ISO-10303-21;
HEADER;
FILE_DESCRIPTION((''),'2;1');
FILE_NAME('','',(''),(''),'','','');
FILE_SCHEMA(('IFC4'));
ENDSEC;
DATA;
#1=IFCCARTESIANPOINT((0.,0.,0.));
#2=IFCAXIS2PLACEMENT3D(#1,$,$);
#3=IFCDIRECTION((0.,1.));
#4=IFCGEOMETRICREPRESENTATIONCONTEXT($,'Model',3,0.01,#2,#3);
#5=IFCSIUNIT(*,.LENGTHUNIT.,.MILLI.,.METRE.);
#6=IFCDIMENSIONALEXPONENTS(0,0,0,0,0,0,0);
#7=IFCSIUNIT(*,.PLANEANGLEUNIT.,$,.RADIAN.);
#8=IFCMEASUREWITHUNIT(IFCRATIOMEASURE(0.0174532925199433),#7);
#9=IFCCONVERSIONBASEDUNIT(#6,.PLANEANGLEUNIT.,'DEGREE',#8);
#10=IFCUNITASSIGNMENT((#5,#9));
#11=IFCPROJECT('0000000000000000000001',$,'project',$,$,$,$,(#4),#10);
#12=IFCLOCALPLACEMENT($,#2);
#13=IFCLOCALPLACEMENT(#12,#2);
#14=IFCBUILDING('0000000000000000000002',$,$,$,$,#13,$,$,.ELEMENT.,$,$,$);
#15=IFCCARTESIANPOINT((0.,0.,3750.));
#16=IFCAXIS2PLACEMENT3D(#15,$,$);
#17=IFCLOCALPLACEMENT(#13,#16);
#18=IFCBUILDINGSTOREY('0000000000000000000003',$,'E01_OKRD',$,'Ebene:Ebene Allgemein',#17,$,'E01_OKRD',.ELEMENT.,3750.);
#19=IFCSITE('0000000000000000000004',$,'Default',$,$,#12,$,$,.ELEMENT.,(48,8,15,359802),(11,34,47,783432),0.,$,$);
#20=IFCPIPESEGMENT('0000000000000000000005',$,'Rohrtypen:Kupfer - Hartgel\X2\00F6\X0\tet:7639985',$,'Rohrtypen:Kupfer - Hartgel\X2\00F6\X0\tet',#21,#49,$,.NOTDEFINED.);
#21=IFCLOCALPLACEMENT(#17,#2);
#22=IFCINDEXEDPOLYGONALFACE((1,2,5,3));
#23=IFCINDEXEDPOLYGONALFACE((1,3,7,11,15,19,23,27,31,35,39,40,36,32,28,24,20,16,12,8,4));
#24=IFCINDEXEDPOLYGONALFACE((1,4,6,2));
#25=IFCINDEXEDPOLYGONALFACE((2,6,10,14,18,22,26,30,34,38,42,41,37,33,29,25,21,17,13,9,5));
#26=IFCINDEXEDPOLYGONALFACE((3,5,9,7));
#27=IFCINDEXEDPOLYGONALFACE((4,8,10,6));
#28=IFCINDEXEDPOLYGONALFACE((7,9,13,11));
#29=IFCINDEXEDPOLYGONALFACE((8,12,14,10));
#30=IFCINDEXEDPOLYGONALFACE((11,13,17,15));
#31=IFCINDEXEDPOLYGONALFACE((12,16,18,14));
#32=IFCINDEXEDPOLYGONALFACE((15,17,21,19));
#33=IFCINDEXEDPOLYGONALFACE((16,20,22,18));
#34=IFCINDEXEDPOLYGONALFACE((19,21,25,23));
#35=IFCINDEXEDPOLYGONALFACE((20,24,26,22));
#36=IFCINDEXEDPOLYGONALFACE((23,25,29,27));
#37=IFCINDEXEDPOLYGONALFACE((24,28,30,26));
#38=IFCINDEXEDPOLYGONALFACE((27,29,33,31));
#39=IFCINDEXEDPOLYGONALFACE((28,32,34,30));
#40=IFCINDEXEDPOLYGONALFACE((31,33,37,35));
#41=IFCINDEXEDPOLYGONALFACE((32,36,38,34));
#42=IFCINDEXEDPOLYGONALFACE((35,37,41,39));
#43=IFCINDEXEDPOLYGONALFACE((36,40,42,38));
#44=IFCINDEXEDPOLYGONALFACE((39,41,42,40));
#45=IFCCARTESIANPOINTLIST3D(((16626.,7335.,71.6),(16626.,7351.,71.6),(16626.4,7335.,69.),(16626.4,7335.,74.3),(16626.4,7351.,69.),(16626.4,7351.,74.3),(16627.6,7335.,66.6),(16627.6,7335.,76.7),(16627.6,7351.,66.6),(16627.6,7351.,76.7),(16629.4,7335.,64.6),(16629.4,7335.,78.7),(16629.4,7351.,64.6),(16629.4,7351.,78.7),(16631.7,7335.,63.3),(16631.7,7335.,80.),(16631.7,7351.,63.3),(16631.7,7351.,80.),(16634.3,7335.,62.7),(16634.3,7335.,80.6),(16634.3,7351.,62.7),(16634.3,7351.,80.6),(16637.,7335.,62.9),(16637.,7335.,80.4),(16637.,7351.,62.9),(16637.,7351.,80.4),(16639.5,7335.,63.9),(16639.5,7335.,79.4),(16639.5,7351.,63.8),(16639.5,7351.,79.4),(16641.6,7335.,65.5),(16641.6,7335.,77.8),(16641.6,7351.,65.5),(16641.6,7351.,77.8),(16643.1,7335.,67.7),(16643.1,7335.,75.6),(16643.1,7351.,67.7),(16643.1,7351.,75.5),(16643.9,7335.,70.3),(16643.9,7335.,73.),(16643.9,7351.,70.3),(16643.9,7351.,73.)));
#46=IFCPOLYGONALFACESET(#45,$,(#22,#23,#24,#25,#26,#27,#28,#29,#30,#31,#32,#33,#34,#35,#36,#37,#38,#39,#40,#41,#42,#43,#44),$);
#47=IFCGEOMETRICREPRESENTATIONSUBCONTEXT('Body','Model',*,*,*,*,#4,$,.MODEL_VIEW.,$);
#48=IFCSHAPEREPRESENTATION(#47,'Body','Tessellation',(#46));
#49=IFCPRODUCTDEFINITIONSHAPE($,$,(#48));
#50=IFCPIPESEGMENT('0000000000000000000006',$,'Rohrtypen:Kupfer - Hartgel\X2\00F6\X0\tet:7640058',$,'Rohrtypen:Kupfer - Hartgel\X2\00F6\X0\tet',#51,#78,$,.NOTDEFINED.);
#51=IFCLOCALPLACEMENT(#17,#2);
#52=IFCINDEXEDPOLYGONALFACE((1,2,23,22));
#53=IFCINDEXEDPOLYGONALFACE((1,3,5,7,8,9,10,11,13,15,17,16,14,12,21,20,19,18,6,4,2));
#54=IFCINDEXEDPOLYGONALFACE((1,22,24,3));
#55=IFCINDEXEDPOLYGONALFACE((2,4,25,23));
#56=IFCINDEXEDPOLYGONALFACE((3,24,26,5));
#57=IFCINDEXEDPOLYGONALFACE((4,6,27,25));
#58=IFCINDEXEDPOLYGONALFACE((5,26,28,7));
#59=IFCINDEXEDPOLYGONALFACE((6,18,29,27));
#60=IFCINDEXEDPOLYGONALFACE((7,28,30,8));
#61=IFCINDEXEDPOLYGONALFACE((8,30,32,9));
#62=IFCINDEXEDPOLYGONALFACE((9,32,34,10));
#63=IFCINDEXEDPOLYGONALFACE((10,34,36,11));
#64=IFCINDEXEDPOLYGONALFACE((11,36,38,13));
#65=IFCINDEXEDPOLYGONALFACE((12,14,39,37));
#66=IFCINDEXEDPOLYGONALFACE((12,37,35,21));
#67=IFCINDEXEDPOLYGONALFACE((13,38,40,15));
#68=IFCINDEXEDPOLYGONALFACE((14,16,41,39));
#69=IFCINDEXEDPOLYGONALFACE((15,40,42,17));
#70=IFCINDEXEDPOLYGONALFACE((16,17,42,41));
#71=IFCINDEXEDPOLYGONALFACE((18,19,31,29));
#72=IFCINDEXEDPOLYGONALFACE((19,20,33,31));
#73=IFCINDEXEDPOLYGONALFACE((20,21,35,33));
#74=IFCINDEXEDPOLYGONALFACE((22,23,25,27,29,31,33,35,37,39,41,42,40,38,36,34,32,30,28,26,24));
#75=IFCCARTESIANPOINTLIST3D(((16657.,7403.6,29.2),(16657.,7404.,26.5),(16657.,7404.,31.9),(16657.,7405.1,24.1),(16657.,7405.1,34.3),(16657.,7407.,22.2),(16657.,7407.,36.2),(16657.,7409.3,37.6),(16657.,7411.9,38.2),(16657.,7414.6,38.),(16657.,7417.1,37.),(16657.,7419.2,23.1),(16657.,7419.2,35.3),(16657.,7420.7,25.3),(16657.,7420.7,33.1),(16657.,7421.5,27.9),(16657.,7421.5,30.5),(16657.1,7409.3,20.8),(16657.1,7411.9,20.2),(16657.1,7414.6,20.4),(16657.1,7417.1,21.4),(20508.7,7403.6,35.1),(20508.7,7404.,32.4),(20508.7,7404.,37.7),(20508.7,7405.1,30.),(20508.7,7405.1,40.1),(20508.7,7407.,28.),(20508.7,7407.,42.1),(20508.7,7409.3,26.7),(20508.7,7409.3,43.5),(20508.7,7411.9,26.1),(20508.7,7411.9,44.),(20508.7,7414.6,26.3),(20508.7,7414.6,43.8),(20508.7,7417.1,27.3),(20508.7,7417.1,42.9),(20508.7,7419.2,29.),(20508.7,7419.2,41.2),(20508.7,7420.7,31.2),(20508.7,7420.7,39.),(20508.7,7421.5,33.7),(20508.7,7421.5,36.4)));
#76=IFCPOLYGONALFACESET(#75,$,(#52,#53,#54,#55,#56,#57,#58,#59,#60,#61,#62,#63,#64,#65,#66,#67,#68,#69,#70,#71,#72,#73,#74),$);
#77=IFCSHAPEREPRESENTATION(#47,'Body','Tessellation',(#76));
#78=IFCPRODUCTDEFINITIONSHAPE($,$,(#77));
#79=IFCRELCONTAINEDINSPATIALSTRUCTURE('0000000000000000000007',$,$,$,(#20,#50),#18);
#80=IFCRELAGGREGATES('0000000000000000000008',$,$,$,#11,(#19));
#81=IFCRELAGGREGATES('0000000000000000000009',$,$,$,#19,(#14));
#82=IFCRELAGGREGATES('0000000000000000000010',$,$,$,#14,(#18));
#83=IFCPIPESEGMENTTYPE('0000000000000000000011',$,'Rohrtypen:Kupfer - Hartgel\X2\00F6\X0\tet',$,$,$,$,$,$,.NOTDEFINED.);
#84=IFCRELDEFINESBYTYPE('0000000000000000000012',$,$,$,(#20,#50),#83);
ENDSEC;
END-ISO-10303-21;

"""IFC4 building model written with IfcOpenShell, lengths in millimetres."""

from ifc_helpers import new_model, entity, si_unit, converted_unit, direction, frame, frame_2d, origin, origin_2d_with_axis, place, context, subcontext, project, spatial, circle, extrude, type_object, element, save


model = new_model("IFC4")

# Units and contexts
model_context = context("Model", 3, precision=0.01, world=origin(), true_north=direction((0.0, 1.0)))
body_context = subcontext(model_context, "Body", "Model", "MODEL_VIEW")
ifc_project = project(units=[si_unit("LENGTHUNIT", "METRE", prefix="MILLI"), converted_unit("PLANEANGLEUNIT", "DEGREE", entity("IfcRatioMeasure", 0.0174532925199433), si_unit("PLANEANGLEUNIT", "RADIAN"), dimensions=[0, 0, 0, 0, 0, 0, 0])], contexts=[model_context])

# Site, building, storey
site_placement = place(None, origin())
site = spatial("IfcSite", under=ifc_project, at=site_placement, Name="Default", CompositionType="ELEMENT", RefLatitude=(48, 8, 15, 359802), RefLongitude=(11, 34, 47, 783432), RefElevation=0.0)
building_placement = place(site_placement, origin())
building = spatial("IfcBuilding", under=site, at=building_placement, CompositionType="ELEMENT")
storey_placement = place(building_placement, frame((0.0, 0.0, 3750.0)))
storey = spatial("IfcBuildingStorey", under=building, at=storey_placement, Name="E01_OKRD", ObjectType="Ebene:Ebene Allgemein", LongName="E01_OKRD", CompositionType="ELEMENT", Elevation=3750.0)

# Pipe segments
pipe_segment_type = type_object("IfcPipeSegmentType", Name="Rohrtypen:Kupfer - Hartgelötet", PredefinedType="NOTDEFINED")
pipe_segment_1_placement = place(storey_placement, frame((16624.4, 7335.0, 61.0)))
element("IfcPipeSegment", 1, at=pipe_segment_1_placement, inside=storey, type_object=pipe_segment_type, Name="Rohrtypen:Kupfer - Hartgelötet:7639985", ObjectType="Rohrtypen:Kupfer - Hartgelötet", PredefinedType="NOTDEFINED", context=body_context, shape_type="SweptSolid", body=[
    extrude(circle(Radius=9.0, at=frame_2d((0.0, 0.0), x_axis=(1.0, 0.0))), frame((10.6, 0.0, 10.6), z_axis=(0.000081, 1.0, -0.000282), x_axis=(-1.0, 0.000081, 0.0)), (0.0, 0.0, 1.0), 16.0),
])
pipe_segment_2_placement = place(storey_placement, frame((16657.0, 7402.0, 18.6)))
element("IfcPipeSegment", 2, at=pipe_segment_2_placement, inside=storey, type_object=pipe_segment_type, Name="Rohrtypen:Kupfer - Hartgelötet:7640058", ObjectType="Rohrtypen:Kupfer - Hartgelötet", PredefinedType="NOTDEFINED", context=body_context, shape_type="SweptSolid", body=[
    extrude(circle(Radius=9.0, at=origin_2d_with_axis()), frame((0.0, 10.6, 10.6), z_axis=(0.999999, 0.0, 0.001525), x_axis=(0.0, -1.0, 0.0)), (0.0, 0.0, 1.0), 3851.7),
])

save(model, "model.ifc")
